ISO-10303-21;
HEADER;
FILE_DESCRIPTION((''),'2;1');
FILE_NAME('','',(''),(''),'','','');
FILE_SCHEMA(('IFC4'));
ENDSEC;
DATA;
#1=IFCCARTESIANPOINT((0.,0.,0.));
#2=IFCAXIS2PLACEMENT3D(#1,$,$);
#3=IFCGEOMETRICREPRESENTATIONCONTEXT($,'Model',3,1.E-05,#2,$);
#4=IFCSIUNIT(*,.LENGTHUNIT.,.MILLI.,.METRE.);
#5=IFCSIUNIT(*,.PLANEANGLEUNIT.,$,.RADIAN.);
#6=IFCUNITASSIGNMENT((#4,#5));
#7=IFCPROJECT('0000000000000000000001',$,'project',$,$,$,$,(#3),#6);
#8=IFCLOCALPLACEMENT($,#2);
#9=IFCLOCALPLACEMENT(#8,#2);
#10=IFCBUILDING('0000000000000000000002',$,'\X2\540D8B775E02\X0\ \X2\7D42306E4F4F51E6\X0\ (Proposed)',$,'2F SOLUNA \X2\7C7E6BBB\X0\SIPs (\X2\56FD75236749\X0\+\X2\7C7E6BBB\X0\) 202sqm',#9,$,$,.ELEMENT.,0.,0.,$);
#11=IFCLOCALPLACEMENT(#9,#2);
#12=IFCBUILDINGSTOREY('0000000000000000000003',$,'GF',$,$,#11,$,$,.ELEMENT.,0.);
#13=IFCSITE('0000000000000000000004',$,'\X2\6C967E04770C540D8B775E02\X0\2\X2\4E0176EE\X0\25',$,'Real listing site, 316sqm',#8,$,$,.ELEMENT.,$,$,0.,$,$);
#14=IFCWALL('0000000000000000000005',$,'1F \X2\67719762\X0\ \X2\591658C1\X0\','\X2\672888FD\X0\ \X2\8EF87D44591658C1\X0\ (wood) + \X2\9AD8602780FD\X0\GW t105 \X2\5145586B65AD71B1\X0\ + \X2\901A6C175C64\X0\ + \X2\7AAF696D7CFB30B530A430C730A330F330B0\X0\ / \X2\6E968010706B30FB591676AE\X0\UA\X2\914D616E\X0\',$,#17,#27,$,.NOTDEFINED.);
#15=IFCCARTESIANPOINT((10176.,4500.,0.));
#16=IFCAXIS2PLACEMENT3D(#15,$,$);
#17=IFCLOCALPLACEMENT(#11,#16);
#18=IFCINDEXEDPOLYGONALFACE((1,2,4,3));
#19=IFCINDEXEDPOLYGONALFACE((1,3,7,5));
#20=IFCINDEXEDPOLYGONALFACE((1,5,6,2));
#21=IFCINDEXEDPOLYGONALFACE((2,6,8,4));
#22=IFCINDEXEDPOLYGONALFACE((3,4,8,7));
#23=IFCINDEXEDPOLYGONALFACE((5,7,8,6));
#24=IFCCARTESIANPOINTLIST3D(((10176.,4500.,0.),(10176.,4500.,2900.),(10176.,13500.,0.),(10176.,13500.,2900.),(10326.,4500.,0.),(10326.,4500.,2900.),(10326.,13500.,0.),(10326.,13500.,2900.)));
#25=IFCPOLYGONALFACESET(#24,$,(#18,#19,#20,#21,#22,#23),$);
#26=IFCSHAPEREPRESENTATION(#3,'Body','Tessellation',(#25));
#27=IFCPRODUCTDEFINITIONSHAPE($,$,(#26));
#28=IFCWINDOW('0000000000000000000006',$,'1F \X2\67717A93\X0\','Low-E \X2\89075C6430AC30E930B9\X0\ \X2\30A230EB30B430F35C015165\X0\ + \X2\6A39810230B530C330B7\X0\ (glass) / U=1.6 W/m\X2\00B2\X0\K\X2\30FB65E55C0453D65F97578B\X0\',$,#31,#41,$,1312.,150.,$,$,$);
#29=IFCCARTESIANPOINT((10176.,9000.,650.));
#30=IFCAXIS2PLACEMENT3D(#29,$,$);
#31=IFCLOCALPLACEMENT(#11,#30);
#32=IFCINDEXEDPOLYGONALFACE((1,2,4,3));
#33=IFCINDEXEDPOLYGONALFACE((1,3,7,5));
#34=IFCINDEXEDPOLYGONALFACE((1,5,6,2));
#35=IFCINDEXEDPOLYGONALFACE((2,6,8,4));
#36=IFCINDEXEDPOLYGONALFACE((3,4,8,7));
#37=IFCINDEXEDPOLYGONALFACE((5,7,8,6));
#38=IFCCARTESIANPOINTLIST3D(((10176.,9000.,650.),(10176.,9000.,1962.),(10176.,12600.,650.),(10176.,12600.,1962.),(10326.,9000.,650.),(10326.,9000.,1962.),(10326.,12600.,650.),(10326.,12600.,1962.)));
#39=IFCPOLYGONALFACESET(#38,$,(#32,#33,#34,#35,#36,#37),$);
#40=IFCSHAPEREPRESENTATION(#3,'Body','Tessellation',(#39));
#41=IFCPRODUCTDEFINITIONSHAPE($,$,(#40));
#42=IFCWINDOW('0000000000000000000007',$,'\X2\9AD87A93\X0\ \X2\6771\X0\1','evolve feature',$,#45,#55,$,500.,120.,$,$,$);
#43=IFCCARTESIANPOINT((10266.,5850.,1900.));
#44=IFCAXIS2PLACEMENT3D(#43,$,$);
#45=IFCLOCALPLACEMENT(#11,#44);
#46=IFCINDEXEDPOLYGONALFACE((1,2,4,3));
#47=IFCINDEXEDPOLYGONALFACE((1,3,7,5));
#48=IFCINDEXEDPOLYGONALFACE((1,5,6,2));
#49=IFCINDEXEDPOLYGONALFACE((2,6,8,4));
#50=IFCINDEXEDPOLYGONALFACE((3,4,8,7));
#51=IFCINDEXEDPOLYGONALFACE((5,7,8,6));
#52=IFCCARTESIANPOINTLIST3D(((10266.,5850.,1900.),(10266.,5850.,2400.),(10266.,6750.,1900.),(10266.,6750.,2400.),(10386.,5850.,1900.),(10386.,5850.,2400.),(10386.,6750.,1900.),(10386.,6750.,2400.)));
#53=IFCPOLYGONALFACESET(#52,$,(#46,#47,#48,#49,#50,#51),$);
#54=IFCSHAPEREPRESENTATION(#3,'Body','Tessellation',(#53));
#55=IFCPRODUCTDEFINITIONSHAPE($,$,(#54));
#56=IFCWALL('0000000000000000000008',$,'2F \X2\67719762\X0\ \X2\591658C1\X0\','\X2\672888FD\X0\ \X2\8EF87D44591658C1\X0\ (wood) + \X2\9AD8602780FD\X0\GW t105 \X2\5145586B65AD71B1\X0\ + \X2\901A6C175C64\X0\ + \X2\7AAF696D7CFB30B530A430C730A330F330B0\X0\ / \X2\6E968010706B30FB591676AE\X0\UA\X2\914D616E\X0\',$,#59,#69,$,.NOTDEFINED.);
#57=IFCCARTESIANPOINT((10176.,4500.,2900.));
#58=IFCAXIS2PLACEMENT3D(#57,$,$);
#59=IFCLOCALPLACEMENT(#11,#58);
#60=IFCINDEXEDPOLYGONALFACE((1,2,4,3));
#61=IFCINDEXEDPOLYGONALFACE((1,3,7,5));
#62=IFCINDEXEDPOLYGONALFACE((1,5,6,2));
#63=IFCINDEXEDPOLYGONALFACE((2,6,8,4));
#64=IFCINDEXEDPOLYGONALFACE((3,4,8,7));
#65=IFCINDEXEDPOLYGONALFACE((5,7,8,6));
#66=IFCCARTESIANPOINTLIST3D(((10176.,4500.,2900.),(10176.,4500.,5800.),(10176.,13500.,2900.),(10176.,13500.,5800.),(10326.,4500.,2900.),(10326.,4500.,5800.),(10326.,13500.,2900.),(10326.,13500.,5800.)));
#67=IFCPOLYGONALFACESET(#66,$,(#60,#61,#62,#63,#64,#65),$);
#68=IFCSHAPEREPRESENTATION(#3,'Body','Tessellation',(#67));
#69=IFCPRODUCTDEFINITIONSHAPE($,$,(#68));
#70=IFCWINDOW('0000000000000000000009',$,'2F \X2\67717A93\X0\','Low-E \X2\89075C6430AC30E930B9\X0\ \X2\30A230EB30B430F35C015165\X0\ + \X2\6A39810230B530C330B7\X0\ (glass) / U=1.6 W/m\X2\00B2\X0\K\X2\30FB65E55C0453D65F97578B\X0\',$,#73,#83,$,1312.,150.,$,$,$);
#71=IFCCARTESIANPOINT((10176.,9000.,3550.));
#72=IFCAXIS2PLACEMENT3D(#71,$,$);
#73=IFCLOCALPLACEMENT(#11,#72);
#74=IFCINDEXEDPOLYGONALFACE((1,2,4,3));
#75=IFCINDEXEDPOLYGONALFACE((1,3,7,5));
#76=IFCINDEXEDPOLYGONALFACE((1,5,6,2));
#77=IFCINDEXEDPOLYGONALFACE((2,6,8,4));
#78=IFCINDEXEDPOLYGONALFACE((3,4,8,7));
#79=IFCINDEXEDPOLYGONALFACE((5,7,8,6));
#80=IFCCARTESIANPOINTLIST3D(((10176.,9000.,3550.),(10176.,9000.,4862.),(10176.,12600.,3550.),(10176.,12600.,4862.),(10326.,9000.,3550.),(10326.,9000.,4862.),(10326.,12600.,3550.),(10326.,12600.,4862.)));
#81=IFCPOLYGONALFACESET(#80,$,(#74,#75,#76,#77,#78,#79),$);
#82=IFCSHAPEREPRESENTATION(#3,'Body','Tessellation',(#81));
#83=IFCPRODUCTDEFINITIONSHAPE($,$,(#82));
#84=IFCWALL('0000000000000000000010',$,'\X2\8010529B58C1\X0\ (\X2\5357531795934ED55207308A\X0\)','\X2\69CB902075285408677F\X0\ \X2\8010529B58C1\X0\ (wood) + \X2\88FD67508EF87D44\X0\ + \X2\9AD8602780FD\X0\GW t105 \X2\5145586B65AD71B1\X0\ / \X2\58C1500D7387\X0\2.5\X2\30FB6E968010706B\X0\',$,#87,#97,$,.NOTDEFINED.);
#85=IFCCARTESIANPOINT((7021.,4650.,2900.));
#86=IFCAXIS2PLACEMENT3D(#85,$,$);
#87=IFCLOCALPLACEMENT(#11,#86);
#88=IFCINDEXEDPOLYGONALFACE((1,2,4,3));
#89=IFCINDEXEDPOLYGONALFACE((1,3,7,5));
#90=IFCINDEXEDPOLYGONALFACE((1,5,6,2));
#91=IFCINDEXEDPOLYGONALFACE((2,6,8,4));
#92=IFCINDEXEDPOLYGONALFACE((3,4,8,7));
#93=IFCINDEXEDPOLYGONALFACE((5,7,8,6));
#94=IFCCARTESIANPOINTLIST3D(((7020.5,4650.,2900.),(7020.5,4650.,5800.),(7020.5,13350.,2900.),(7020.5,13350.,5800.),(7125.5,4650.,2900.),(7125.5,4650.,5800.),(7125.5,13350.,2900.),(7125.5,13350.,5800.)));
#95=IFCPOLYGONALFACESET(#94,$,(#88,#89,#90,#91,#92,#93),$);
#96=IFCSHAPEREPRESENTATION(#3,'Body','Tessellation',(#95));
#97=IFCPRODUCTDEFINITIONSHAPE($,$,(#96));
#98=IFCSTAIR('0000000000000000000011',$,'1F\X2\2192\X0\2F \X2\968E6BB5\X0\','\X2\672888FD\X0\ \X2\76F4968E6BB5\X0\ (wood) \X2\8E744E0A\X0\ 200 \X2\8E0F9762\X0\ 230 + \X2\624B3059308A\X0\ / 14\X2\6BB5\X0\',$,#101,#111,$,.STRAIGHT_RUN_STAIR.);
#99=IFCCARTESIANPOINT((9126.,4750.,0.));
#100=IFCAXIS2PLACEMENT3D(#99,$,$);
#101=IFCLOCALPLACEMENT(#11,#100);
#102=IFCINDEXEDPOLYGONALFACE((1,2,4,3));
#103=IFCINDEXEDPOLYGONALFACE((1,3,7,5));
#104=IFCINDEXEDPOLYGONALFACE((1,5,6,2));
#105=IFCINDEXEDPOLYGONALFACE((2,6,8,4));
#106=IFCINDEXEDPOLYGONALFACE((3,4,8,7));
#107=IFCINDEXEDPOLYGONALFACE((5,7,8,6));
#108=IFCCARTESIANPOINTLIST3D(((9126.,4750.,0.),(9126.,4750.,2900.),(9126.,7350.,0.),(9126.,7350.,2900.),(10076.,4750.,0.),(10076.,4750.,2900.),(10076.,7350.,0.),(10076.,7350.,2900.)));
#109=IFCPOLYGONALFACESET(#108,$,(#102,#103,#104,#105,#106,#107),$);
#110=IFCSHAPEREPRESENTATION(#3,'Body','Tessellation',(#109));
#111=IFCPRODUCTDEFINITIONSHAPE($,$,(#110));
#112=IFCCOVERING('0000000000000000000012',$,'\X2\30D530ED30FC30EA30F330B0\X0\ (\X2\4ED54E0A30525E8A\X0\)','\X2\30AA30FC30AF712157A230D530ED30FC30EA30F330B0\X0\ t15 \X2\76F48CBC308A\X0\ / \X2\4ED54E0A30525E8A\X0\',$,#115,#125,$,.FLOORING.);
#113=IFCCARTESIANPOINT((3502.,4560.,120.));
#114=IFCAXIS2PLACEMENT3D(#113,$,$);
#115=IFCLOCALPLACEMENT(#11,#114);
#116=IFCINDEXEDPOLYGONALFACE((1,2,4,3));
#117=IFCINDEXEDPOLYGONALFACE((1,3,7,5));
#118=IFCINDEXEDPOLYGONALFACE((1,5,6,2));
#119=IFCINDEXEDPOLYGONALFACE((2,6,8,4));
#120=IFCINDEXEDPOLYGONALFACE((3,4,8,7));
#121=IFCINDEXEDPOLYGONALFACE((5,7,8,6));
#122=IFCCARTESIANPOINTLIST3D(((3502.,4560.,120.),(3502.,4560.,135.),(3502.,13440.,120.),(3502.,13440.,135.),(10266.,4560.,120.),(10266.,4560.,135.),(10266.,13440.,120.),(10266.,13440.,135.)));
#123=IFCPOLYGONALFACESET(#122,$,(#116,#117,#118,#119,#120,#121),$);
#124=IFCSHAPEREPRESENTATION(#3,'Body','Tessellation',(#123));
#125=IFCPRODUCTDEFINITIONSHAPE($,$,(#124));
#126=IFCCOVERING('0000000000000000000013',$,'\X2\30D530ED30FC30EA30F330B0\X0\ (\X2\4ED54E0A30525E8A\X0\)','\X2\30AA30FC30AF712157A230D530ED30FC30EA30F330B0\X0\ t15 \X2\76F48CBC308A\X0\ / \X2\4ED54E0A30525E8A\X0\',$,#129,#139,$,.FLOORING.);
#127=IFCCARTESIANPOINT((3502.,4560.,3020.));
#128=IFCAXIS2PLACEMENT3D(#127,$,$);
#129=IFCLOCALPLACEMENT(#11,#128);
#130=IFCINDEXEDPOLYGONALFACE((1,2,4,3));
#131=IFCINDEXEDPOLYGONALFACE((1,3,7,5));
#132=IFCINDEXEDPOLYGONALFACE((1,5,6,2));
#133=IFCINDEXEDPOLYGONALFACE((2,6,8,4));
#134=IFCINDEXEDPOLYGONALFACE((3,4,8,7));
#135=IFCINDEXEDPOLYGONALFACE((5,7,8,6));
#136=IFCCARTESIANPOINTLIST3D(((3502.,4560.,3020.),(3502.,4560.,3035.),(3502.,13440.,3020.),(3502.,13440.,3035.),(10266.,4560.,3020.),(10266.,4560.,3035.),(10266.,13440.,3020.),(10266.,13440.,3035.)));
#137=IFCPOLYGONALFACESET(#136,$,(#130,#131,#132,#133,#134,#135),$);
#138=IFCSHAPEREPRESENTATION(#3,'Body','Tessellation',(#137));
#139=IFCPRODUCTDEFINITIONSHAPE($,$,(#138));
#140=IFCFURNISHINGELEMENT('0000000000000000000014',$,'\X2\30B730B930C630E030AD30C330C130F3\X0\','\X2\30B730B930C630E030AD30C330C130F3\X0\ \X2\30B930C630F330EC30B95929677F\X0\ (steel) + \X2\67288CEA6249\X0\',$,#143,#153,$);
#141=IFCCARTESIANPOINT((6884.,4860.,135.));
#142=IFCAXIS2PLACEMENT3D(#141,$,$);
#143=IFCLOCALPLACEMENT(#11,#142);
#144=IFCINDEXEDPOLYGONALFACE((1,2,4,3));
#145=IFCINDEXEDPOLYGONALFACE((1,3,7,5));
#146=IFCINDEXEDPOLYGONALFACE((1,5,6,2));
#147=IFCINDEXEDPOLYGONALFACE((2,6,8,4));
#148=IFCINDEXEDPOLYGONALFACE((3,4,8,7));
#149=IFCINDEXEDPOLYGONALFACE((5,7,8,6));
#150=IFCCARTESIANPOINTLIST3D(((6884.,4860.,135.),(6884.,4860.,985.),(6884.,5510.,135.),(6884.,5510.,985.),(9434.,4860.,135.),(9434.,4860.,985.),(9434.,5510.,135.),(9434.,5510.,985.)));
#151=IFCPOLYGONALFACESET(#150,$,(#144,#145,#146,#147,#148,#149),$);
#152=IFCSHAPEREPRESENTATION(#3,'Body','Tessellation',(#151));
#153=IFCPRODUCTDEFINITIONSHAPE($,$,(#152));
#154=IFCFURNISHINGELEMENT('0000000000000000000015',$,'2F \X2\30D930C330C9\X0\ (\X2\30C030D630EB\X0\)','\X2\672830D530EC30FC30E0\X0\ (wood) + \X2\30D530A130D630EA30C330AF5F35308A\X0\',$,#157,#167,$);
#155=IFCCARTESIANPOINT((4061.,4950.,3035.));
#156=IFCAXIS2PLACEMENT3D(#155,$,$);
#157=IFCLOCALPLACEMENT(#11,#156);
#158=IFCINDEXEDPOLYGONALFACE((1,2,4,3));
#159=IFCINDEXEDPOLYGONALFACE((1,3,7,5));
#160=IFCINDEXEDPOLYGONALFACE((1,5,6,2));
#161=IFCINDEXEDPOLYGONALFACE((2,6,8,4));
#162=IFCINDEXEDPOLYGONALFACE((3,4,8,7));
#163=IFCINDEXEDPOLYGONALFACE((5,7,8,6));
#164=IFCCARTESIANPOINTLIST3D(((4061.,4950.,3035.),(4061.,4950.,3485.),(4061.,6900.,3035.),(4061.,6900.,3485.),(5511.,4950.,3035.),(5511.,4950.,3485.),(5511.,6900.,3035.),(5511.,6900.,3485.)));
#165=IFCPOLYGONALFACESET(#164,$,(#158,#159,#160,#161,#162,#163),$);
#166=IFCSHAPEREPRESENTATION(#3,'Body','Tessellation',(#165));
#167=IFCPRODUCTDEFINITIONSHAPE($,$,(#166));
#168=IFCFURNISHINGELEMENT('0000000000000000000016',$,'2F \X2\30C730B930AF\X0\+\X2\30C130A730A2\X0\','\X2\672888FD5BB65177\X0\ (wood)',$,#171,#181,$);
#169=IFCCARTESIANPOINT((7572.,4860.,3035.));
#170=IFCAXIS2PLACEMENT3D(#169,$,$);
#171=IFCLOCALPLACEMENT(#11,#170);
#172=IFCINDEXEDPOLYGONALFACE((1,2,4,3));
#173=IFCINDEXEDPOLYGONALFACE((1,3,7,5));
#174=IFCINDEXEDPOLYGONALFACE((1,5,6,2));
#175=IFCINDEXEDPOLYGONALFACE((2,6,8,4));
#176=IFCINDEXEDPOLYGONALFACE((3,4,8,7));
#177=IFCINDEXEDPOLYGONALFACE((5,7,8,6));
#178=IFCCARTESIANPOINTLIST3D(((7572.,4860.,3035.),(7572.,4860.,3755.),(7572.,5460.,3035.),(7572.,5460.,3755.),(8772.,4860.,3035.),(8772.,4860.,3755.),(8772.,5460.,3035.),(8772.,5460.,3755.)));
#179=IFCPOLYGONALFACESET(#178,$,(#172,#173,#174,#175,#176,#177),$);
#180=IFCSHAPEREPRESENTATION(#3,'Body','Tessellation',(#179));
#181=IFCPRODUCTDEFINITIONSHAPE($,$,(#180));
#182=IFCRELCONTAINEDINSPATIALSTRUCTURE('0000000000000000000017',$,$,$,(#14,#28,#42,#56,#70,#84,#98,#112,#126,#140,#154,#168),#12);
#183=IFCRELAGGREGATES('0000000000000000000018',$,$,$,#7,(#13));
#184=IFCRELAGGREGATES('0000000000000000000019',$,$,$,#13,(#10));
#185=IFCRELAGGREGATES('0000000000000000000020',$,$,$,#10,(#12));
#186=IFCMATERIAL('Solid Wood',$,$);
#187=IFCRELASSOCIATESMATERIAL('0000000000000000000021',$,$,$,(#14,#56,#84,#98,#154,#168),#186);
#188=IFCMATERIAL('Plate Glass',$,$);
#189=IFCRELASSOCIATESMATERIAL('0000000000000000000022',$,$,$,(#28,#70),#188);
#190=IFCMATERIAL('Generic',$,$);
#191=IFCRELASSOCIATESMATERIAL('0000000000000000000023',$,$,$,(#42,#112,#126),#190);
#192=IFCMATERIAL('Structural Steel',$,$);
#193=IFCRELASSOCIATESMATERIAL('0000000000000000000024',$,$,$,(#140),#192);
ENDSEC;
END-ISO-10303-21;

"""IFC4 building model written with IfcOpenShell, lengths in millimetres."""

from ifc_helpers import new_model, si_unit, frame, frame_2d, origin, place, context, project, spatial, rectangle, extrude, material, element, fill, save


model = new_model("IFC4")

# Units and contexts
model_context = context("Model", 3, precision=1e-05, world=origin())
ifc_project = project(units=[si_unit("LENGTHUNIT", "METRE", prefix="MILLI"), si_unit("PLANEANGLEUNIT", "RADIAN")], contexts=[model_context])

# Site, building, storey
site_placement = place(None, origin())
site = spatial("IfcSite", under=ifc_project, at=site_placement, Name="沖縄県名護市2丁目25", ObjectType="Real listing site, 316sqm", CompositionType="ELEMENT", RefElevation=0.0)
building_placement = place(site_placement, origin())
building = spatial("IfcBuilding", under=site, at=building_placement, Name="名護市 終の住処 (Proposed)", ObjectType="2F SOLUNA 籾殻SIPs (国産杉+籾殻) 202sqm", CompositionType="ELEMENT", ElevationOfRefHeight=0.0, ElevationOfTerrain=0.0)
storey_placement = place(building_placement, origin())
storey = spatial("IfcBuildingStorey", under=building, at=storey_placement, Name="GF", CompositionType="ELEMENT", Elevation=0.0)

# Shared definitions
ifc_material_1 = material(Name="Solid Wood")

# Wall, openings, windows
wall_1_placement = place(storey_placement, frame((10176.0, 4500.0, 0.0)))
wall_1 = element("IfcWall", 1, at=wall_1_placement, inside=storey, material=ifc_material_1, Name="1F 東面 外壁", Description="木製 軸組外壁 (wood) + 高性能GW t105 充填断熱 + 通気層 + 窯業系サイディング / 準耐火・外皮UA配慮", PredefinedType="NOTDEFINED", context=model_context, shape_type="SweptSolid", body=[
    extrude(rectangle(XDim=150.0, YDim=9000.0, at=frame_2d((75.0, 4500.0))), frame((10176.0, 4500.0, 0.0)), (0.0, 0.0, 1.0), 2900.0),
])
opening_1_placement = place(storey_placement, frame((10176.0, 9000.0, 650.0)))
opening_1 = element("IfcOpeningElement", 2, at=opening_1_placement, cuts=wall_1, PredefinedType="NOTDEFINED", context=model_context, shape_type="SweptSolid", body=[
    extrude(rectangle(XDim=150.0, YDim=3600.0, at=frame_2d((75.0, 1800.0))), frame((10176.0, 9000.0, 650.0)), (0.0, 0.0, 1.0), 1312.0),
])
opening_2_placement = place(storey_placement, frame((10266.0, 5850.0, 1900.0)))
opening_2 = element("IfcOpeningElement", 3, at=opening_2_placement, cuts=wall_1, PredefinedType="NOTDEFINED", context=model_context, shape_type="SweptSolid", body=[
    extrude(rectangle(XDim=120.0, YDim=900.0, at=frame_2d((60.0, 450.0))), frame((10266.0, 5850.0, 1900.0)), (0.0, 0.0, 1.0), 500.0),
])
ifc_material_2 = material(Name="Plate Glass")
window_1_placement = place(storey_placement, frame((10176.0, 9000.0, 650.0)))
window_1 = element("IfcWindow", 4, at=window_1_placement, inside=storey, material=ifc_material_2, Name="1F 東窓", Description="Low-E 複層ガラス アルゴン封入 + 樹脂サッシ (glass) / U=1.6 W/m²K・日射取得型", OverallHeight=1312.0, OverallWidth=150.0, context=model_context, shape_type="SweptSolid", body=[
    extrude(rectangle(XDim=150.0, YDim=3600.0, at=frame_2d((75.0, 1800.0))), frame((10176.0, 9000.0, 650.0)), (0.0, 0.0, 1.0), 1312.0),
])
fill(opening_1, window_1)
ifc_material_3 = material(Name="Generic")
window_2_placement = place(storey_placement, frame((10266.0, 5850.0, 1900.0)))
window_2 = element("IfcWindow", 5, at=window_2_placement, inside=storey, material=ifc_material_3, Name="高窓 東1", Description="evolve feature", OverallHeight=500.0, OverallWidth=120.0, context=model_context, shape_type="SweptSolid", body=[
    extrude(rectangle(XDim=120.0, YDim=900.0, at=frame_2d((60.0, 450.0))), frame((10266.0, 5850.0, 1900.0)), (0.0, 0.0, 1.0), 500.0),
])
fill(opening_2, window_2)

# Wall, opening, window
wall_2_placement = place(storey_placement, frame((10176.0, 4500.0, 2900.0)))
wall_2 = element("IfcWall", 6, at=wall_2_placement, inside=storey, material=ifc_material_1, Name="2F 東面 外壁", Description="木製 軸組外壁 (wood) + 高性能GW t105 充填断熱 + 通気層 + 窯業系サイディング / 準耐火・外皮UA配慮", PredefinedType="NOTDEFINED", context=model_context, shape_type="SweptSolid", body=[
    extrude(rectangle(XDim=150.0, YDim=9000.0, at=frame_2d((75.0, 4500.0))), frame((10176.0, 4500.0, 2900.0)), (0.0, 0.0, 1.0), 2900.0),
])
opening_3_placement = place(storey_placement, frame((10176.0, 9000.0, 3550.0)))
opening_3 = element("IfcOpeningElement", 7, at=opening_3_placement, cuts=wall_2, PredefinedType="NOTDEFINED", context=model_context, shape_type="SweptSolid", body=[
    extrude(rectangle(XDim=150.0, YDim=3600.0, at=frame_2d((75.0, 1800.0))), frame((10176.0, 9000.0, 3550.0)), (0.0, 0.0, 1.0), 1312.0),
])
window_3_placement = place(storey_placement, frame((10176.0, 9000.0, 3550.0)))
window_3 = element("IfcWindow", 8, at=window_3_placement, inside=storey, material=ifc_material_2, Name="2F 東窓", Description="Low-E 複層ガラス アルゴン封入 + 樹脂サッシ (glass) / U=1.6 W/m²K・日射取得型", OverallHeight=1312.0, OverallWidth=150.0, context=model_context, shape_type="SweptSolid", body=[
    extrude(rectangle(XDim=150.0, YDim=3600.0, at=frame_2d((75.0, 1800.0))), frame((10176.0, 9000.0, 3550.0)), (0.0, 0.0, 1.0), 1312.0),
])
fill(opening_3, window_3)

# Wall
wall_3_placement = place(storey_placement, frame((7021.0, 4650.0, 2900.0)))
element("IfcWall", 9, at=wall_3_placement, inside=storey, material=ifc_material_1, Name="耐力壁 (南北間仕切り)", Description="構造用合板 耐力壁 (wood) + 製材軸組 + 高性能GW t105 充填断熱 / 壁倍率2.5・準耐火", PredefinedType="NOTDEFINED", context=model_context, shape_type="SweptSolid", body=[
    extrude(rectangle(XDim=105.0, YDim=8700.0, at=frame_2d((52.0, 4350.0))), frame((7021.0, 4650.0, 2900.0)), (0.0, 0.0, 1.0), 2900.0),
])

# Stair
stair_placement = place(storey_placement, frame((9126.0, 4750.0, 0.0)))
element("IfcStair", 10, at=stair_placement, inside=storey, material=ifc_material_1, Name="1F→2F 階段", Description="木製 直階段 (wood) 蹴上 200 踏面 230 + 手すり / 14段", PredefinedType="STRAIGHT_RUN_STAIR", context=model_context, shape_type="SweptSolid", body=[
    extrude(rectangle(XDim=950.0, YDim=2600.0, at=frame_2d((475.0, 1300.0))), frame((9126.0, 4750.0, 0.0)), (0.0, 0.0, 1.0), 2900.0),
])

# Coverings
covering_1_placement = place(storey_placement, frame((3502.0, 4560.0, 120.0)))
element("IfcCovering", 11, at=covering_1_placement, inside=storey, material=ifc_material_3, Name="フローリング (仕上げ床)", Description="オーク無垢フローリング t15 直貼り / 仕上げ床", PredefinedType="FLOORING", context=model_context, shape_type="SweptSolid", body=[
    extrude(rectangle(XDim=6764.0, YDim=8880.0, at=frame_2d((3382.0, 4440.0))), frame((3502.0, 4560.0, 120.0)), (0.0, 0.0, 1.0), 15.0),
])
covering_2_placement = place(storey_placement, frame((3502.0, 4560.0, 3020.0)))
element("IfcCovering", 12, at=covering_2_placement, inside=storey, material=ifc_material_3, Name="フローリング (仕上げ床)", Description="オーク無垢フローリング t15 直貼り / 仕上げ床", PredefinedType="FLOORING", context=model_context, shape_type="SweptSolid", body=[
    extrude(rectangle(XDim=6764.0, YDim=8880.0, at=frame_2d((3382.0, 4440.0))), frame((3502.0, 4560.0, 3020.0)), (0.0, 0.0, 1.0), 15.0),
])

# Furnishing elements
ifc_material_4 = material(Name="Structural Steel")
furnishing_1_placement = place(storey_placement, frame((6884.0, 4860.0, 135.0)))
element("IfcFurnishingElement", 13, at=furnishing_1_placement, inside=storey, material=ifc_material_4, Name="システムキッチン", Description="システムキッチン ステンレス天板 (steel) + 木質扉", context=model_context, shape_type="SweptSolid", body=[
    extrude(rectangle(XDim=2550.0, YDim=650.0, at=frame_2d((1275.0, 325.0))), frame((6884.0, 4860.0, 135.0)), (0.0, 0.0, 1.0), 850.0),
])
furnishing_2_placement = place(storey_placement, frame((4061.0, 4950.0, 3035.0)))
element("IfcFurnishingElement", 14, at=furnishing_2_placement, inside=storey, material=ifc_material_1, Name="2F ベッド (ダブル)", Description="木フレーム (wood) + ファブリック張り", context=model_context, shape_type="SweptSolid", body=[
    extrude(rectangle(XDim=1450.0, YDim=1950.0, at=frame_2d((725.0, 975.0))), frame((4061.0, 4950.0, 3035.0)), (0.0, 0.0, 1.0), 450.0),
])
furnishing_3_placement = place(storey_placement, frame((7572.0, 4860.0, 3035.0)))
element("IfcFurnishingElement", 15, at=furnishing_3_placement, inside=storey, material=ifc_material_1, Name="2F デスク+チェア", Description="木製家具 (wood)", context=model_context, shape_type="SweptSolid", body=[
    extrude(rectangle(XDim=1200.0, YDim=600.0, at=frame_2d((600.0, 300.0))), frame((7572.0, 4860.0, 3035.0)), (0.0, 0.0, 1.0), 720.0),
])

save(model, "model.ifc")
